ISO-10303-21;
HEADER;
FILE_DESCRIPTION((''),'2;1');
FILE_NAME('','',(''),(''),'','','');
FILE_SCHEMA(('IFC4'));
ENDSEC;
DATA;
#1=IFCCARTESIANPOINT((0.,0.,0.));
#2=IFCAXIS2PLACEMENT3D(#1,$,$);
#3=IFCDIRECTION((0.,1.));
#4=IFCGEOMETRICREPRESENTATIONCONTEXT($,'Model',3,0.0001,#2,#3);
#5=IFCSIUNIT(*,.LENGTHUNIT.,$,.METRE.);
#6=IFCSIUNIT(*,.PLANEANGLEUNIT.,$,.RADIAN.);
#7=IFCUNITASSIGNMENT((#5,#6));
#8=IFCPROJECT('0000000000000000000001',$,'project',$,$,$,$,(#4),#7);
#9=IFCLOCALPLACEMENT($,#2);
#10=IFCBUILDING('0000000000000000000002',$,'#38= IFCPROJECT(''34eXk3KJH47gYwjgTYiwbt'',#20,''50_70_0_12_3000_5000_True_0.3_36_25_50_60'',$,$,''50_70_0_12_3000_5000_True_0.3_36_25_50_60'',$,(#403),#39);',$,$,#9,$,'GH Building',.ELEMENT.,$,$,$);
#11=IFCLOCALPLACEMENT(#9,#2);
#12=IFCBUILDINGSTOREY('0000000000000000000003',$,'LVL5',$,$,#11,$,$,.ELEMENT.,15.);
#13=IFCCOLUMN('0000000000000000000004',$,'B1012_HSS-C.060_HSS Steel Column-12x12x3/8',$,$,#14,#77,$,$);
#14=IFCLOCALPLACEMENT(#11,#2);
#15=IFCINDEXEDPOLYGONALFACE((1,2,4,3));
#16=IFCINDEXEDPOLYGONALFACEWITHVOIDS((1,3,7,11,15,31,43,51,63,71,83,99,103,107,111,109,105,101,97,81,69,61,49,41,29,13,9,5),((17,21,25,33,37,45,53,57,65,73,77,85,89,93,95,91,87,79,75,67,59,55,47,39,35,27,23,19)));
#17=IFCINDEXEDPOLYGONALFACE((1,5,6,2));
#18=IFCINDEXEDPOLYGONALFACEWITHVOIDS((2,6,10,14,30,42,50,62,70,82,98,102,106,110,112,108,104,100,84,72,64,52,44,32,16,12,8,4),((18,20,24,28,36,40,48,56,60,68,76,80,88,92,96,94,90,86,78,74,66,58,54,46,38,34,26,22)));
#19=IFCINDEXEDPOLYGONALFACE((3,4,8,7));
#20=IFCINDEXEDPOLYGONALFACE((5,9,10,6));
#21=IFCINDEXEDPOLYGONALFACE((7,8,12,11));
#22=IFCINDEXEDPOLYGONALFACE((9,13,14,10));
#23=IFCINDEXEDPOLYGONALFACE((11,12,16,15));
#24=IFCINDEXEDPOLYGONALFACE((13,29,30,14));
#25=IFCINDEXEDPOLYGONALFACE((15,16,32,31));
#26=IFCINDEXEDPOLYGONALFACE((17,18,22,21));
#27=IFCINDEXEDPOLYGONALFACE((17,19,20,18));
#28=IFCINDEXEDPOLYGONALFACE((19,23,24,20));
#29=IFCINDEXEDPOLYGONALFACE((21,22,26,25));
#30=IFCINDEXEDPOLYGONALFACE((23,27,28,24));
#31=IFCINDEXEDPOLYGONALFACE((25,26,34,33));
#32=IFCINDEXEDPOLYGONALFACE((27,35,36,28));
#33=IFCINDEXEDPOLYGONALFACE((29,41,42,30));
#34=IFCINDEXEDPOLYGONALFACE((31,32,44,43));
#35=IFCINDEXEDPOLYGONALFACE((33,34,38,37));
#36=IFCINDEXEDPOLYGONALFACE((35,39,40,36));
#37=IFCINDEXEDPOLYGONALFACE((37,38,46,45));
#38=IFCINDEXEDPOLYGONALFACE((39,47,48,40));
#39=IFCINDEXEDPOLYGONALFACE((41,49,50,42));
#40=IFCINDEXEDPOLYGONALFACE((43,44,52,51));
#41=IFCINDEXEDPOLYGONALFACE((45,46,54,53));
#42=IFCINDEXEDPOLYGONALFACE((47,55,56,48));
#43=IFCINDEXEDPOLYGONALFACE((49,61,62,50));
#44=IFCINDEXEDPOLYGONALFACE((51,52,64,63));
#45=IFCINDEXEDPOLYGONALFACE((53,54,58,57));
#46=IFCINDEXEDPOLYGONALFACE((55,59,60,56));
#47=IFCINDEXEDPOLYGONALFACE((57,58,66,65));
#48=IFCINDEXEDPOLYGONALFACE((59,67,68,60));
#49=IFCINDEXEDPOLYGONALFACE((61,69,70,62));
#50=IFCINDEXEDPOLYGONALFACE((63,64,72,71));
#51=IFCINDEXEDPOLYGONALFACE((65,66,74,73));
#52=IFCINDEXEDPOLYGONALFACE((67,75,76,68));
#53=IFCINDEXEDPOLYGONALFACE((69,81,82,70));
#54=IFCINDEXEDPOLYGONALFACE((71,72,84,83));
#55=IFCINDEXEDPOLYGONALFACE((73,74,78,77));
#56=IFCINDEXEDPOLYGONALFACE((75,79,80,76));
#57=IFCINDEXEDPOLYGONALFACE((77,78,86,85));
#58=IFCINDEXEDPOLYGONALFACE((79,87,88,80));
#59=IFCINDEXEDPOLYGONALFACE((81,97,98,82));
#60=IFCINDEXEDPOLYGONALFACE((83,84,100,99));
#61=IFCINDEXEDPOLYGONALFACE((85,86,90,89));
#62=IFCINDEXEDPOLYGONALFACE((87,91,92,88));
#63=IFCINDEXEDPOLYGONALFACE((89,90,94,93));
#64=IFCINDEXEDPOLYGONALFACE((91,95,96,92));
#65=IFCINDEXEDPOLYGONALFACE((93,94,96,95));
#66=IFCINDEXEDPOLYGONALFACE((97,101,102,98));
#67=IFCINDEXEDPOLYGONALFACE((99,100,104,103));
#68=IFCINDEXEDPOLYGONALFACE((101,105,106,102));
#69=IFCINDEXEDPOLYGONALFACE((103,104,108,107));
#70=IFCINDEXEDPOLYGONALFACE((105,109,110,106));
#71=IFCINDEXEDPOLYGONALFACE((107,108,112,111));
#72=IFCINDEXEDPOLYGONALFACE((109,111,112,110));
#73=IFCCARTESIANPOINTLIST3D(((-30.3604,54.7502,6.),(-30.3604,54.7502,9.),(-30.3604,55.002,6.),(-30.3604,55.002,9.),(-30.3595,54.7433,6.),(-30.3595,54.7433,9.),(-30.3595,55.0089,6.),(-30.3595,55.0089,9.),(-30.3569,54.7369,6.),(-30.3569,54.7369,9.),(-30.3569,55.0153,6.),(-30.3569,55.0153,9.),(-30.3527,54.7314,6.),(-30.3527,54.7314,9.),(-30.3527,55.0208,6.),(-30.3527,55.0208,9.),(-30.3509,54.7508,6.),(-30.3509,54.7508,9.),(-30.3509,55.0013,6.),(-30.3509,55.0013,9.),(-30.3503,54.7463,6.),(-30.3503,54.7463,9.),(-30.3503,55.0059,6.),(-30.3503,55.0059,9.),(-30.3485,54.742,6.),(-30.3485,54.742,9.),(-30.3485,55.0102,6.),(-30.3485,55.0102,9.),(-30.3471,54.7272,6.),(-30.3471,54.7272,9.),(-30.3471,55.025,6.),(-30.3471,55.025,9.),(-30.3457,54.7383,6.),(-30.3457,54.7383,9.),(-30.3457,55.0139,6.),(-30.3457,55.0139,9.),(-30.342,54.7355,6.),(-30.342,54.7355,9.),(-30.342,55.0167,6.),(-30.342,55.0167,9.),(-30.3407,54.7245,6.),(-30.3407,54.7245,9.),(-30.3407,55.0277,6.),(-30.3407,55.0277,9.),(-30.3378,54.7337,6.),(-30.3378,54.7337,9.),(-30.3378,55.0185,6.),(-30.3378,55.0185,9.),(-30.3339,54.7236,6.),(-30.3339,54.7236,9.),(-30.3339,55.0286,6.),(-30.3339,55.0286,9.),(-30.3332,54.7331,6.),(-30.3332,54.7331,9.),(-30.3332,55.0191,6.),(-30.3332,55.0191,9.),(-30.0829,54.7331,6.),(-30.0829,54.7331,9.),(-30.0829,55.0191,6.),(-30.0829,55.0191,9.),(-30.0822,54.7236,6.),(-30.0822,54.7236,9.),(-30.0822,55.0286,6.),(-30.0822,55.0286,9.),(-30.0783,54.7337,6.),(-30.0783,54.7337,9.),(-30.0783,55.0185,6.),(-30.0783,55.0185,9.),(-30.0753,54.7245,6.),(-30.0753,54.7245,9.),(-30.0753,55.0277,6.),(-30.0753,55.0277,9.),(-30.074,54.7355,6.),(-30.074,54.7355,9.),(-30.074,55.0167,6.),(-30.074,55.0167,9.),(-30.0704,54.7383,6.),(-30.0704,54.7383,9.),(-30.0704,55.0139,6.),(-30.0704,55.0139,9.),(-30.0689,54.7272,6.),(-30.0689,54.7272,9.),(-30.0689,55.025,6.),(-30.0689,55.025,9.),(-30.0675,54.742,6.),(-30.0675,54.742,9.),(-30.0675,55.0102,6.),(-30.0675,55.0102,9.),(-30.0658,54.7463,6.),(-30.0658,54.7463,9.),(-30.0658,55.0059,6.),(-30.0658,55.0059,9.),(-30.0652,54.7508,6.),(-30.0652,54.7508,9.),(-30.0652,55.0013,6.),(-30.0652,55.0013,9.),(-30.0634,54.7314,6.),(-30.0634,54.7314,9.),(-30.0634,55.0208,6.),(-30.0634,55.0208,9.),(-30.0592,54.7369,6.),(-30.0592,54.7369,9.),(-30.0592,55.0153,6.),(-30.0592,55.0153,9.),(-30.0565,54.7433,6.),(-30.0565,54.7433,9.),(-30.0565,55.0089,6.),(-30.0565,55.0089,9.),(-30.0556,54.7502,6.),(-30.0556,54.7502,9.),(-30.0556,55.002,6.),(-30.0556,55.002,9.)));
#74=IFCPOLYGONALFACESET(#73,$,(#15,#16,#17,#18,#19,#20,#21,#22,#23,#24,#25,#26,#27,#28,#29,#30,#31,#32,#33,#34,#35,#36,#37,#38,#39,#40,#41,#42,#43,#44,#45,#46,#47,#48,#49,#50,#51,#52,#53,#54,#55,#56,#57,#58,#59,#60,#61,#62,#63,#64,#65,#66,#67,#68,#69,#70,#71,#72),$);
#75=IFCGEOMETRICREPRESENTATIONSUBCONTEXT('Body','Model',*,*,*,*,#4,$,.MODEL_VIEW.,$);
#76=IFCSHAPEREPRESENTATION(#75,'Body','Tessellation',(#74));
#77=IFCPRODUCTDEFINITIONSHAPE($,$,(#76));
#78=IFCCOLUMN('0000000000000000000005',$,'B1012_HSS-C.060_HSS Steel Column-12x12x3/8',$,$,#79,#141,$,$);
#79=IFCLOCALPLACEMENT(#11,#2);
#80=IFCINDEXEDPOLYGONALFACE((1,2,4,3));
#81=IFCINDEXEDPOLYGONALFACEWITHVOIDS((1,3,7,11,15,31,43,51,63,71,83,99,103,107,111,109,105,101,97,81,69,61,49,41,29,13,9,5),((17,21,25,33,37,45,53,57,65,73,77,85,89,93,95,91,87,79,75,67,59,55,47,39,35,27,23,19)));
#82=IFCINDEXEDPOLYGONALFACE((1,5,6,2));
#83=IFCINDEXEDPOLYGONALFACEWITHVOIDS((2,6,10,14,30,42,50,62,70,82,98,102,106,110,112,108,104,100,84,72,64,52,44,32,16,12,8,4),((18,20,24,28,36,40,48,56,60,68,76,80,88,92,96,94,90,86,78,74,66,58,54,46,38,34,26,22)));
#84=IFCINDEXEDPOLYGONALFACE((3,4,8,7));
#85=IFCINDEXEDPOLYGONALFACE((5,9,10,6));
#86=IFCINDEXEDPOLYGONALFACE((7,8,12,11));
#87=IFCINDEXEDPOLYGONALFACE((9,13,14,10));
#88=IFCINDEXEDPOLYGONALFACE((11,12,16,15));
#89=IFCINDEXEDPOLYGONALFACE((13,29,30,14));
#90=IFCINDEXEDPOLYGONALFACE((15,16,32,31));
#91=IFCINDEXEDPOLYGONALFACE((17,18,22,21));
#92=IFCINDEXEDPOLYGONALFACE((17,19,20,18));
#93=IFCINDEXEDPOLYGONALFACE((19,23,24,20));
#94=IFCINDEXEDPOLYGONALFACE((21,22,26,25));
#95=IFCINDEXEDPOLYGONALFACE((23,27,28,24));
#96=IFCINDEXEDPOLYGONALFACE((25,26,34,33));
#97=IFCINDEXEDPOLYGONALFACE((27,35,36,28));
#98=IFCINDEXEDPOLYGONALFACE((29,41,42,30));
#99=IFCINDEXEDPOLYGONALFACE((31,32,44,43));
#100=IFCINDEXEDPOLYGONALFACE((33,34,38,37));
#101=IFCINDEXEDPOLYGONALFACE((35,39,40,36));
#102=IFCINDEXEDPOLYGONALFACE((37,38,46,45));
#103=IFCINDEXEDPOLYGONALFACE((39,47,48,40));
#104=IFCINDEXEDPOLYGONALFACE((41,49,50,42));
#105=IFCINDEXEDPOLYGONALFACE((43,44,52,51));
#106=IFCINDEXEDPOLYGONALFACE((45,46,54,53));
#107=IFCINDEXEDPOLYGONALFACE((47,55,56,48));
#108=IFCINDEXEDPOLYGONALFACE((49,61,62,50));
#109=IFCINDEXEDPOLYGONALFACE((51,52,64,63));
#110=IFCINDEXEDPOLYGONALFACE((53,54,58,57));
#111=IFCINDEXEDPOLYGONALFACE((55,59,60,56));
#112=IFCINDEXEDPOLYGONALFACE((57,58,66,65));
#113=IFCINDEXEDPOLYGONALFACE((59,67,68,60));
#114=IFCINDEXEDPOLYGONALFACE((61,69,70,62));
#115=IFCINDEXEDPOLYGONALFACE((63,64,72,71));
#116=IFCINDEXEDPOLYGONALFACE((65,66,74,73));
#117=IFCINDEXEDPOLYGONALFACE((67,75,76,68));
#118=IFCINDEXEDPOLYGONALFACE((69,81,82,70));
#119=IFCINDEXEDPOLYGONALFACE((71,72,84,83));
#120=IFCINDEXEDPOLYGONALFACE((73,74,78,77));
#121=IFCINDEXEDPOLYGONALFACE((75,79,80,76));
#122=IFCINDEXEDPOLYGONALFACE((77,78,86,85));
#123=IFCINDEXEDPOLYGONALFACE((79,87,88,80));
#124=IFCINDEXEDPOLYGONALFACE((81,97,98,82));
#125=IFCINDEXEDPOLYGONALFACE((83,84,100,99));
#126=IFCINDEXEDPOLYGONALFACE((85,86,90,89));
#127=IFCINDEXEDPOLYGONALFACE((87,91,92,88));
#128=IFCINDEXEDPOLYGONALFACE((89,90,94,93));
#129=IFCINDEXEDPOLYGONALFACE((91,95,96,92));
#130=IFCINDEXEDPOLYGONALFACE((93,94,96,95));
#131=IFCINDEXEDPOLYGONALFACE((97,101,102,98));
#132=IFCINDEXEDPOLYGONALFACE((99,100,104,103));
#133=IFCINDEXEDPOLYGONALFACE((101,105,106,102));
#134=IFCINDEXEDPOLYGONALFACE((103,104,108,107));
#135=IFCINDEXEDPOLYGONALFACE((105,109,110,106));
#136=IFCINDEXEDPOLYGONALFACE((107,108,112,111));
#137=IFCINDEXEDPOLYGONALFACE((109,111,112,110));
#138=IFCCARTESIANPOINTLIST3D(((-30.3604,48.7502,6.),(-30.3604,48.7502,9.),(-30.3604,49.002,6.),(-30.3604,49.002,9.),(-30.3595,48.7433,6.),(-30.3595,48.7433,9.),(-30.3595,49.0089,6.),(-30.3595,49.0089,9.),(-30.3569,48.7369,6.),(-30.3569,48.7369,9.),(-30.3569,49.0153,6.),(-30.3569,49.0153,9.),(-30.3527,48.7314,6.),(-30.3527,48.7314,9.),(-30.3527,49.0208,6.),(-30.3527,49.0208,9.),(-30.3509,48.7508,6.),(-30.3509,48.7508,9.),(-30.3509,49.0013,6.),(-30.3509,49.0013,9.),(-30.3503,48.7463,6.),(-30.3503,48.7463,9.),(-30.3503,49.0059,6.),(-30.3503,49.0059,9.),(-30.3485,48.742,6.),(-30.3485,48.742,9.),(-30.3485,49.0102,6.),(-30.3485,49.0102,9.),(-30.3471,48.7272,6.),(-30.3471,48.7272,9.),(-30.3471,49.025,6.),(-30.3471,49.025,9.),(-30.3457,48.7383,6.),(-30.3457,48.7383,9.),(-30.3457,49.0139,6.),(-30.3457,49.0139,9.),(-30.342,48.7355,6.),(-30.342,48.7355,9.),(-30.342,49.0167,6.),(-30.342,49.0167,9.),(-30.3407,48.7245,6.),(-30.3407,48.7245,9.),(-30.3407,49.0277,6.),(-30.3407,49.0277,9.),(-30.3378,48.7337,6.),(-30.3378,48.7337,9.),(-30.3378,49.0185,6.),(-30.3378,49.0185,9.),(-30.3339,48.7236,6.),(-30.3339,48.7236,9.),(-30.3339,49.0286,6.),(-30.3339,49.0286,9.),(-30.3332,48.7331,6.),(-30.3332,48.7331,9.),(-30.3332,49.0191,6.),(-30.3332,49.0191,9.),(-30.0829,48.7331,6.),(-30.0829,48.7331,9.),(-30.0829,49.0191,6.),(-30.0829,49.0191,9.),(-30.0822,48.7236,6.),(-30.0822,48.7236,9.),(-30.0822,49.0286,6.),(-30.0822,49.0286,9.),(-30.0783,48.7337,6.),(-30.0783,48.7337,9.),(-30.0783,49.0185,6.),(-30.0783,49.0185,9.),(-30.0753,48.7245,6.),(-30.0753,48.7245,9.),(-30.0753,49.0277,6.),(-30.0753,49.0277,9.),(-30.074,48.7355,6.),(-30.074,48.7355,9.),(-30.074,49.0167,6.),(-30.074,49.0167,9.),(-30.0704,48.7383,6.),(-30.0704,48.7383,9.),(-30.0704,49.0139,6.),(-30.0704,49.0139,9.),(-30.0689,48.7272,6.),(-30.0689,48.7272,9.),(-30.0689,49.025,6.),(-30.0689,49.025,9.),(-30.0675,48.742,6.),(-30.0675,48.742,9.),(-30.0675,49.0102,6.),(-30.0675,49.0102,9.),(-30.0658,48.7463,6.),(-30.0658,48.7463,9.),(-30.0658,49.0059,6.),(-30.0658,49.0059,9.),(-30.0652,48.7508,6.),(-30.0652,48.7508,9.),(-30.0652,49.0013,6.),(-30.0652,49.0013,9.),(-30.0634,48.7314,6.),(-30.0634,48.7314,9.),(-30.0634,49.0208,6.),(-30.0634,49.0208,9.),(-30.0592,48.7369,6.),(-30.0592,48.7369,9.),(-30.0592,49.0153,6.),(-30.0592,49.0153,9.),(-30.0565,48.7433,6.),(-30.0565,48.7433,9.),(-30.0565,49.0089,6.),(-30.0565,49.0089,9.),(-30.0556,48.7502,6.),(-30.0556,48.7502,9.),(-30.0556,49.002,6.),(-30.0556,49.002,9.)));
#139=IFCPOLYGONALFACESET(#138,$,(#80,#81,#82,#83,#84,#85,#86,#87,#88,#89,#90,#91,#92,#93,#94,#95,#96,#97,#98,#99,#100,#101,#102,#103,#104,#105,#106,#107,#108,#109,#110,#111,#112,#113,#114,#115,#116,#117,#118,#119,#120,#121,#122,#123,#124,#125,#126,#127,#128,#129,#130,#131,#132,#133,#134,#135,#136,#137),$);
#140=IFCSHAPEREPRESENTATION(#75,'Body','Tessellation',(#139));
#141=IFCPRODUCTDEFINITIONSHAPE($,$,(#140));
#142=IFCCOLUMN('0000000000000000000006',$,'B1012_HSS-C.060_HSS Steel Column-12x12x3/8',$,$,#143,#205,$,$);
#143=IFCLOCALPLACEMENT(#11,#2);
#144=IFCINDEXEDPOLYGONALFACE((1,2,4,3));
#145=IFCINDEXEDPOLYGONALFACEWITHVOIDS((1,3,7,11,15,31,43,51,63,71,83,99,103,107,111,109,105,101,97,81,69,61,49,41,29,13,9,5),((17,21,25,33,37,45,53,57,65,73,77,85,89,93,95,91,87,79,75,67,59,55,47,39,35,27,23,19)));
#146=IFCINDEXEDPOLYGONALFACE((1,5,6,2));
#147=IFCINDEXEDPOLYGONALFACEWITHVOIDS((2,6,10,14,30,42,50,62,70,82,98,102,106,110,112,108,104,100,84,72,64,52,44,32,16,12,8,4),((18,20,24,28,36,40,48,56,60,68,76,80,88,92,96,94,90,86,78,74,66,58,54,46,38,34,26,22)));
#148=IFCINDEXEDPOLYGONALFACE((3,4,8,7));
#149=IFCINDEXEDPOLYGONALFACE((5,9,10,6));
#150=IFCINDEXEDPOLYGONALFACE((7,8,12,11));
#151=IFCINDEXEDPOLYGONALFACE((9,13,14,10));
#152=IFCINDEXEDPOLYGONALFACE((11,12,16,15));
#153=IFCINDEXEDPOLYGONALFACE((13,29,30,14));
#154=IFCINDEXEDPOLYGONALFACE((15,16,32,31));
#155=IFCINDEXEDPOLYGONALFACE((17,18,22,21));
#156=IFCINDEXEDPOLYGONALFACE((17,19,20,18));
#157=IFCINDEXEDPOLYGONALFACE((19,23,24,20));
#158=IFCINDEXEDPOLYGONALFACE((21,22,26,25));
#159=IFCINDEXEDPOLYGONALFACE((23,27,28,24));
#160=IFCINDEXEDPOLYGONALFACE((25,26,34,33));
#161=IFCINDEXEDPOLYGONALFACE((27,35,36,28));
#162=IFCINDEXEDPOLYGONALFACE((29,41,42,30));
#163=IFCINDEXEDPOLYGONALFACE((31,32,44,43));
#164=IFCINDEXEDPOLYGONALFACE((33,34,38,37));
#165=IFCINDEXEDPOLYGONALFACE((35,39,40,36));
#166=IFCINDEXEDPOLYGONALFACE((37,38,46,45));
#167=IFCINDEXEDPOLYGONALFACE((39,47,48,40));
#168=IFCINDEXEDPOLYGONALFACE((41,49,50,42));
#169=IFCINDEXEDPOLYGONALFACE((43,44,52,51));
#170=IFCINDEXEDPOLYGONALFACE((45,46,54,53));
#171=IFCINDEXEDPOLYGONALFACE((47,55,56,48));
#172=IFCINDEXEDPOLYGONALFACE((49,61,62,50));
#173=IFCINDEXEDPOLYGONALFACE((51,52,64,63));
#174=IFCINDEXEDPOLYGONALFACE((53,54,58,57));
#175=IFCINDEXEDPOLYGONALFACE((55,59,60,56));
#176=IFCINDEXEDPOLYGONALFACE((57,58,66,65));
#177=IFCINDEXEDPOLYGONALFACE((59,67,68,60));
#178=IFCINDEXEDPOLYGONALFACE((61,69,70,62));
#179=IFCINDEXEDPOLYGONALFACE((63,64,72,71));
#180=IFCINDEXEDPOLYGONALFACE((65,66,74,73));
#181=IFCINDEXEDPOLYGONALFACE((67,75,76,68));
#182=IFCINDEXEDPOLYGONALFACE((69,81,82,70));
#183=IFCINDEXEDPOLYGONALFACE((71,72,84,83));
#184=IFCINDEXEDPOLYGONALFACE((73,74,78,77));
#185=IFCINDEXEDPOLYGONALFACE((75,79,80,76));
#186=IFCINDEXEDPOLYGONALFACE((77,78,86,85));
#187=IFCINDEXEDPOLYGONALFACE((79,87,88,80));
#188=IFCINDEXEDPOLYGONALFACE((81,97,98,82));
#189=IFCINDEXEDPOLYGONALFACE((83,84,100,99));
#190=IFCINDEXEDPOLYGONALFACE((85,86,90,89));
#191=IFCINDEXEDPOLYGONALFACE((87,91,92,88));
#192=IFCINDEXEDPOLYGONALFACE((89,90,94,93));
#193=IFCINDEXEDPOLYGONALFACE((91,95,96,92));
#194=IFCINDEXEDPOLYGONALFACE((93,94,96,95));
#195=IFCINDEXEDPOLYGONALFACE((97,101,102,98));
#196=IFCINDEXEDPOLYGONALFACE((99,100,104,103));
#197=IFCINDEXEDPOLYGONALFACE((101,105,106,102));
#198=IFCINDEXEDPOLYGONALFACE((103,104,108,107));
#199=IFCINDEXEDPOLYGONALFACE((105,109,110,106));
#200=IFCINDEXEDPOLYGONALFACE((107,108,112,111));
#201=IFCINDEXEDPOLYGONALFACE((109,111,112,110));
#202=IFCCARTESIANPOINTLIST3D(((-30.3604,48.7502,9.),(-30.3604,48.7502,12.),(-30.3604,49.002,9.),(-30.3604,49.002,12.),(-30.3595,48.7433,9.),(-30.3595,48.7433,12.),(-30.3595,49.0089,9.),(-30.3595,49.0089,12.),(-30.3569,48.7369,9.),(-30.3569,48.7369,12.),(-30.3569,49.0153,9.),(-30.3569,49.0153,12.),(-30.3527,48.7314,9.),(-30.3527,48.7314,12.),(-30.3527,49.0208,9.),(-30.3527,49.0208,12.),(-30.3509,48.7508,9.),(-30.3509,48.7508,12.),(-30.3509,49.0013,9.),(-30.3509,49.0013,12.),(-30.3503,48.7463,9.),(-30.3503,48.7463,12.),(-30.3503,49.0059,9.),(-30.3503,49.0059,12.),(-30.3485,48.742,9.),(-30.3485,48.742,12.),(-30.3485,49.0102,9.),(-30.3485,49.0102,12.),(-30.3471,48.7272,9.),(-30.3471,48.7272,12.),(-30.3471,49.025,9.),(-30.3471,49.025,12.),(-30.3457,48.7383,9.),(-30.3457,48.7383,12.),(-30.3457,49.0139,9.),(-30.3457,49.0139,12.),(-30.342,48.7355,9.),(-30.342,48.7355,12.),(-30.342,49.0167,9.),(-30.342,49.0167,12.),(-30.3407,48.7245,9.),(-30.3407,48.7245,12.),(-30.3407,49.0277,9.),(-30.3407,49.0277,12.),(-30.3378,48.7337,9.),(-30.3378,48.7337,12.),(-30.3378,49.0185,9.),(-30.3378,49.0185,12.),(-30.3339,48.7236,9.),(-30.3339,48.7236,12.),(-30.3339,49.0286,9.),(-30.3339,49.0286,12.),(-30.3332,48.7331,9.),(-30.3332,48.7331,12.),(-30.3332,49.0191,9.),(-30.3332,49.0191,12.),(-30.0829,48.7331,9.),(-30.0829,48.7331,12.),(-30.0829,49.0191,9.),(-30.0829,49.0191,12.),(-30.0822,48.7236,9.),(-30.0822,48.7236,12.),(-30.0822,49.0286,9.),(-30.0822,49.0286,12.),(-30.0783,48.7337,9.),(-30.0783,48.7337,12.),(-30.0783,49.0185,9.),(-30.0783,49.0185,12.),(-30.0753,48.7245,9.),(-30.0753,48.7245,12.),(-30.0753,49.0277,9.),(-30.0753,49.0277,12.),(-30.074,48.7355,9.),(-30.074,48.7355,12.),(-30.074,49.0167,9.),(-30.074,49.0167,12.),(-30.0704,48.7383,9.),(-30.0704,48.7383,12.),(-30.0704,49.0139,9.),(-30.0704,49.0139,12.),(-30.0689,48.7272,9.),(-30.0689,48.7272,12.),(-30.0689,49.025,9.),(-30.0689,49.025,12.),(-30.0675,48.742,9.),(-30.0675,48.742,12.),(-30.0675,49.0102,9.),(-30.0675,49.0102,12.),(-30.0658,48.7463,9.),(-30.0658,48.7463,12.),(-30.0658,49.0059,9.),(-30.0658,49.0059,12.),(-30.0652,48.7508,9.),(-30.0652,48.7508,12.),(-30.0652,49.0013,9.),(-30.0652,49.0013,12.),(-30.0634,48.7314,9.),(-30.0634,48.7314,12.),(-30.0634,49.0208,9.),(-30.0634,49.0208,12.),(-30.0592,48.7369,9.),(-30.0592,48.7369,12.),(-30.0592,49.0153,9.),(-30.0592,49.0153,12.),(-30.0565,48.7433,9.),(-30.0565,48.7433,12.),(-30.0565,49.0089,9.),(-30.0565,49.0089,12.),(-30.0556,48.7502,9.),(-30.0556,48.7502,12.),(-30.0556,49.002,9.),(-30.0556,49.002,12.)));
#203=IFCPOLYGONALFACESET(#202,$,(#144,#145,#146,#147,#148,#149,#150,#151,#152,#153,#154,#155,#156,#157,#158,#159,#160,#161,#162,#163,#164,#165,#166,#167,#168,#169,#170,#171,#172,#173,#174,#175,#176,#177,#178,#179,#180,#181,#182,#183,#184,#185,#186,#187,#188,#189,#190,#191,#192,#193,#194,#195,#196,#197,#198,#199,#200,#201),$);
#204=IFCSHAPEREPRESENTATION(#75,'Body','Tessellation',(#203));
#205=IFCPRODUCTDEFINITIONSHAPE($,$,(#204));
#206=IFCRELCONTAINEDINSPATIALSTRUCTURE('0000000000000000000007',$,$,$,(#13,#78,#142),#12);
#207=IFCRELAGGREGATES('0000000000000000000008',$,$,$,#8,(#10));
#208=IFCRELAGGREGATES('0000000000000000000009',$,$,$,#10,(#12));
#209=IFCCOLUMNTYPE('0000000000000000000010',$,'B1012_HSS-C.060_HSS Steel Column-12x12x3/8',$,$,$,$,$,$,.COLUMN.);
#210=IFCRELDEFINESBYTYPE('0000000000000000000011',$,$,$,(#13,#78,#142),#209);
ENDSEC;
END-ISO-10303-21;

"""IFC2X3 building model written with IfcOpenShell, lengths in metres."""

from ifc_helpers import new_model, si_unit, direction, frame, origin, origin_2d, place, context, subcontext, project, spatial, hollow_rectangle, extrude, type_object, element, save


model = new_model("IFC2X3")

# Units and contexts
model_context = context("Model", 3, precision=0.0001, world=origin(), true_north=direction((0.0, 1.0)))
body_context = subcontext(model_context, "Body", "Model", "MODEL_VIEW")
ifc_project = project(units=[si_unit("LENGTHUNIT", "METRE"), si_unit("PLANEANGLEUNIT", "RADIAN")], contexts=[model_context])

# Building, storey
building_placement = place(None, origin())
building = spatial("IfcBuilding", under=ifc_project, at=building_placement, Name="#38= IFCPROJECT('34eXk3KJH47gYwjgTYiwbt',#20,'50_70_0_12_3000_5000_True_0.3_36_25_50_60',$,$,'50_70_0_12_3000_5000_True_0.3_36_25_50_60',$,(#403),#39);", LongName="GH Building", CompositionType="ELEMENT")
storey_placement = place(building_placement, origin())
storey = spatial("IfcBuildingStorey", under=building, at=storey_placement, Name="LVL5", CompositionType="ELEMENT", Elevation=15.0)

# Columns
column_type = type_object("IfcColumnType", Name="B1012_HSS-C.060_HSS Steel Column-12x12x3/8", PredefinedType="COLUMN")
for number, where, z_axis, x_axis, name in (
    (1, (-30.208, 54.8761, 9.0), (0.0, 0.0, -1.0), (-1.0, 0.0, 0.0), "B1012_HSS-C.060_HSS Steel Column-12x12x3/8"),
    (2, (-30.208, 48.8761, 9.0), (0.0, 0.0, -1.0), (-1.0, 0.0, 0.0), "B1012_HSS-C.060_HSS Steel Column-12x12x3/8"),
    (3, (-30.208, 48.8761, 12.0), (0.0, 0.0, -1.0), (-1.0, 0.0, 0.0), "B1012_HSS-C.060_HSS Steel Column-12x12x3/8"),
):
    element("IfcColumn", number, at=place(storey_placement, frame(where, z_axis=z_axis, x_axis=x_axis)), inside=storey, type_object=column_type, Name=name, context=body_context, shape_type="SweptSolid", body=[
        extrude(hollow_rectangle(XDim=0.3048, YDim=0.305, WallThickness=0.0095, InnerFilletRadius=0.0177, OuterFilletRadius=0.0266, at=origin_2d()), origin(), (0.0, 0.0, 1.0), 3.0),
    ])

save(model, "model.ifc")
